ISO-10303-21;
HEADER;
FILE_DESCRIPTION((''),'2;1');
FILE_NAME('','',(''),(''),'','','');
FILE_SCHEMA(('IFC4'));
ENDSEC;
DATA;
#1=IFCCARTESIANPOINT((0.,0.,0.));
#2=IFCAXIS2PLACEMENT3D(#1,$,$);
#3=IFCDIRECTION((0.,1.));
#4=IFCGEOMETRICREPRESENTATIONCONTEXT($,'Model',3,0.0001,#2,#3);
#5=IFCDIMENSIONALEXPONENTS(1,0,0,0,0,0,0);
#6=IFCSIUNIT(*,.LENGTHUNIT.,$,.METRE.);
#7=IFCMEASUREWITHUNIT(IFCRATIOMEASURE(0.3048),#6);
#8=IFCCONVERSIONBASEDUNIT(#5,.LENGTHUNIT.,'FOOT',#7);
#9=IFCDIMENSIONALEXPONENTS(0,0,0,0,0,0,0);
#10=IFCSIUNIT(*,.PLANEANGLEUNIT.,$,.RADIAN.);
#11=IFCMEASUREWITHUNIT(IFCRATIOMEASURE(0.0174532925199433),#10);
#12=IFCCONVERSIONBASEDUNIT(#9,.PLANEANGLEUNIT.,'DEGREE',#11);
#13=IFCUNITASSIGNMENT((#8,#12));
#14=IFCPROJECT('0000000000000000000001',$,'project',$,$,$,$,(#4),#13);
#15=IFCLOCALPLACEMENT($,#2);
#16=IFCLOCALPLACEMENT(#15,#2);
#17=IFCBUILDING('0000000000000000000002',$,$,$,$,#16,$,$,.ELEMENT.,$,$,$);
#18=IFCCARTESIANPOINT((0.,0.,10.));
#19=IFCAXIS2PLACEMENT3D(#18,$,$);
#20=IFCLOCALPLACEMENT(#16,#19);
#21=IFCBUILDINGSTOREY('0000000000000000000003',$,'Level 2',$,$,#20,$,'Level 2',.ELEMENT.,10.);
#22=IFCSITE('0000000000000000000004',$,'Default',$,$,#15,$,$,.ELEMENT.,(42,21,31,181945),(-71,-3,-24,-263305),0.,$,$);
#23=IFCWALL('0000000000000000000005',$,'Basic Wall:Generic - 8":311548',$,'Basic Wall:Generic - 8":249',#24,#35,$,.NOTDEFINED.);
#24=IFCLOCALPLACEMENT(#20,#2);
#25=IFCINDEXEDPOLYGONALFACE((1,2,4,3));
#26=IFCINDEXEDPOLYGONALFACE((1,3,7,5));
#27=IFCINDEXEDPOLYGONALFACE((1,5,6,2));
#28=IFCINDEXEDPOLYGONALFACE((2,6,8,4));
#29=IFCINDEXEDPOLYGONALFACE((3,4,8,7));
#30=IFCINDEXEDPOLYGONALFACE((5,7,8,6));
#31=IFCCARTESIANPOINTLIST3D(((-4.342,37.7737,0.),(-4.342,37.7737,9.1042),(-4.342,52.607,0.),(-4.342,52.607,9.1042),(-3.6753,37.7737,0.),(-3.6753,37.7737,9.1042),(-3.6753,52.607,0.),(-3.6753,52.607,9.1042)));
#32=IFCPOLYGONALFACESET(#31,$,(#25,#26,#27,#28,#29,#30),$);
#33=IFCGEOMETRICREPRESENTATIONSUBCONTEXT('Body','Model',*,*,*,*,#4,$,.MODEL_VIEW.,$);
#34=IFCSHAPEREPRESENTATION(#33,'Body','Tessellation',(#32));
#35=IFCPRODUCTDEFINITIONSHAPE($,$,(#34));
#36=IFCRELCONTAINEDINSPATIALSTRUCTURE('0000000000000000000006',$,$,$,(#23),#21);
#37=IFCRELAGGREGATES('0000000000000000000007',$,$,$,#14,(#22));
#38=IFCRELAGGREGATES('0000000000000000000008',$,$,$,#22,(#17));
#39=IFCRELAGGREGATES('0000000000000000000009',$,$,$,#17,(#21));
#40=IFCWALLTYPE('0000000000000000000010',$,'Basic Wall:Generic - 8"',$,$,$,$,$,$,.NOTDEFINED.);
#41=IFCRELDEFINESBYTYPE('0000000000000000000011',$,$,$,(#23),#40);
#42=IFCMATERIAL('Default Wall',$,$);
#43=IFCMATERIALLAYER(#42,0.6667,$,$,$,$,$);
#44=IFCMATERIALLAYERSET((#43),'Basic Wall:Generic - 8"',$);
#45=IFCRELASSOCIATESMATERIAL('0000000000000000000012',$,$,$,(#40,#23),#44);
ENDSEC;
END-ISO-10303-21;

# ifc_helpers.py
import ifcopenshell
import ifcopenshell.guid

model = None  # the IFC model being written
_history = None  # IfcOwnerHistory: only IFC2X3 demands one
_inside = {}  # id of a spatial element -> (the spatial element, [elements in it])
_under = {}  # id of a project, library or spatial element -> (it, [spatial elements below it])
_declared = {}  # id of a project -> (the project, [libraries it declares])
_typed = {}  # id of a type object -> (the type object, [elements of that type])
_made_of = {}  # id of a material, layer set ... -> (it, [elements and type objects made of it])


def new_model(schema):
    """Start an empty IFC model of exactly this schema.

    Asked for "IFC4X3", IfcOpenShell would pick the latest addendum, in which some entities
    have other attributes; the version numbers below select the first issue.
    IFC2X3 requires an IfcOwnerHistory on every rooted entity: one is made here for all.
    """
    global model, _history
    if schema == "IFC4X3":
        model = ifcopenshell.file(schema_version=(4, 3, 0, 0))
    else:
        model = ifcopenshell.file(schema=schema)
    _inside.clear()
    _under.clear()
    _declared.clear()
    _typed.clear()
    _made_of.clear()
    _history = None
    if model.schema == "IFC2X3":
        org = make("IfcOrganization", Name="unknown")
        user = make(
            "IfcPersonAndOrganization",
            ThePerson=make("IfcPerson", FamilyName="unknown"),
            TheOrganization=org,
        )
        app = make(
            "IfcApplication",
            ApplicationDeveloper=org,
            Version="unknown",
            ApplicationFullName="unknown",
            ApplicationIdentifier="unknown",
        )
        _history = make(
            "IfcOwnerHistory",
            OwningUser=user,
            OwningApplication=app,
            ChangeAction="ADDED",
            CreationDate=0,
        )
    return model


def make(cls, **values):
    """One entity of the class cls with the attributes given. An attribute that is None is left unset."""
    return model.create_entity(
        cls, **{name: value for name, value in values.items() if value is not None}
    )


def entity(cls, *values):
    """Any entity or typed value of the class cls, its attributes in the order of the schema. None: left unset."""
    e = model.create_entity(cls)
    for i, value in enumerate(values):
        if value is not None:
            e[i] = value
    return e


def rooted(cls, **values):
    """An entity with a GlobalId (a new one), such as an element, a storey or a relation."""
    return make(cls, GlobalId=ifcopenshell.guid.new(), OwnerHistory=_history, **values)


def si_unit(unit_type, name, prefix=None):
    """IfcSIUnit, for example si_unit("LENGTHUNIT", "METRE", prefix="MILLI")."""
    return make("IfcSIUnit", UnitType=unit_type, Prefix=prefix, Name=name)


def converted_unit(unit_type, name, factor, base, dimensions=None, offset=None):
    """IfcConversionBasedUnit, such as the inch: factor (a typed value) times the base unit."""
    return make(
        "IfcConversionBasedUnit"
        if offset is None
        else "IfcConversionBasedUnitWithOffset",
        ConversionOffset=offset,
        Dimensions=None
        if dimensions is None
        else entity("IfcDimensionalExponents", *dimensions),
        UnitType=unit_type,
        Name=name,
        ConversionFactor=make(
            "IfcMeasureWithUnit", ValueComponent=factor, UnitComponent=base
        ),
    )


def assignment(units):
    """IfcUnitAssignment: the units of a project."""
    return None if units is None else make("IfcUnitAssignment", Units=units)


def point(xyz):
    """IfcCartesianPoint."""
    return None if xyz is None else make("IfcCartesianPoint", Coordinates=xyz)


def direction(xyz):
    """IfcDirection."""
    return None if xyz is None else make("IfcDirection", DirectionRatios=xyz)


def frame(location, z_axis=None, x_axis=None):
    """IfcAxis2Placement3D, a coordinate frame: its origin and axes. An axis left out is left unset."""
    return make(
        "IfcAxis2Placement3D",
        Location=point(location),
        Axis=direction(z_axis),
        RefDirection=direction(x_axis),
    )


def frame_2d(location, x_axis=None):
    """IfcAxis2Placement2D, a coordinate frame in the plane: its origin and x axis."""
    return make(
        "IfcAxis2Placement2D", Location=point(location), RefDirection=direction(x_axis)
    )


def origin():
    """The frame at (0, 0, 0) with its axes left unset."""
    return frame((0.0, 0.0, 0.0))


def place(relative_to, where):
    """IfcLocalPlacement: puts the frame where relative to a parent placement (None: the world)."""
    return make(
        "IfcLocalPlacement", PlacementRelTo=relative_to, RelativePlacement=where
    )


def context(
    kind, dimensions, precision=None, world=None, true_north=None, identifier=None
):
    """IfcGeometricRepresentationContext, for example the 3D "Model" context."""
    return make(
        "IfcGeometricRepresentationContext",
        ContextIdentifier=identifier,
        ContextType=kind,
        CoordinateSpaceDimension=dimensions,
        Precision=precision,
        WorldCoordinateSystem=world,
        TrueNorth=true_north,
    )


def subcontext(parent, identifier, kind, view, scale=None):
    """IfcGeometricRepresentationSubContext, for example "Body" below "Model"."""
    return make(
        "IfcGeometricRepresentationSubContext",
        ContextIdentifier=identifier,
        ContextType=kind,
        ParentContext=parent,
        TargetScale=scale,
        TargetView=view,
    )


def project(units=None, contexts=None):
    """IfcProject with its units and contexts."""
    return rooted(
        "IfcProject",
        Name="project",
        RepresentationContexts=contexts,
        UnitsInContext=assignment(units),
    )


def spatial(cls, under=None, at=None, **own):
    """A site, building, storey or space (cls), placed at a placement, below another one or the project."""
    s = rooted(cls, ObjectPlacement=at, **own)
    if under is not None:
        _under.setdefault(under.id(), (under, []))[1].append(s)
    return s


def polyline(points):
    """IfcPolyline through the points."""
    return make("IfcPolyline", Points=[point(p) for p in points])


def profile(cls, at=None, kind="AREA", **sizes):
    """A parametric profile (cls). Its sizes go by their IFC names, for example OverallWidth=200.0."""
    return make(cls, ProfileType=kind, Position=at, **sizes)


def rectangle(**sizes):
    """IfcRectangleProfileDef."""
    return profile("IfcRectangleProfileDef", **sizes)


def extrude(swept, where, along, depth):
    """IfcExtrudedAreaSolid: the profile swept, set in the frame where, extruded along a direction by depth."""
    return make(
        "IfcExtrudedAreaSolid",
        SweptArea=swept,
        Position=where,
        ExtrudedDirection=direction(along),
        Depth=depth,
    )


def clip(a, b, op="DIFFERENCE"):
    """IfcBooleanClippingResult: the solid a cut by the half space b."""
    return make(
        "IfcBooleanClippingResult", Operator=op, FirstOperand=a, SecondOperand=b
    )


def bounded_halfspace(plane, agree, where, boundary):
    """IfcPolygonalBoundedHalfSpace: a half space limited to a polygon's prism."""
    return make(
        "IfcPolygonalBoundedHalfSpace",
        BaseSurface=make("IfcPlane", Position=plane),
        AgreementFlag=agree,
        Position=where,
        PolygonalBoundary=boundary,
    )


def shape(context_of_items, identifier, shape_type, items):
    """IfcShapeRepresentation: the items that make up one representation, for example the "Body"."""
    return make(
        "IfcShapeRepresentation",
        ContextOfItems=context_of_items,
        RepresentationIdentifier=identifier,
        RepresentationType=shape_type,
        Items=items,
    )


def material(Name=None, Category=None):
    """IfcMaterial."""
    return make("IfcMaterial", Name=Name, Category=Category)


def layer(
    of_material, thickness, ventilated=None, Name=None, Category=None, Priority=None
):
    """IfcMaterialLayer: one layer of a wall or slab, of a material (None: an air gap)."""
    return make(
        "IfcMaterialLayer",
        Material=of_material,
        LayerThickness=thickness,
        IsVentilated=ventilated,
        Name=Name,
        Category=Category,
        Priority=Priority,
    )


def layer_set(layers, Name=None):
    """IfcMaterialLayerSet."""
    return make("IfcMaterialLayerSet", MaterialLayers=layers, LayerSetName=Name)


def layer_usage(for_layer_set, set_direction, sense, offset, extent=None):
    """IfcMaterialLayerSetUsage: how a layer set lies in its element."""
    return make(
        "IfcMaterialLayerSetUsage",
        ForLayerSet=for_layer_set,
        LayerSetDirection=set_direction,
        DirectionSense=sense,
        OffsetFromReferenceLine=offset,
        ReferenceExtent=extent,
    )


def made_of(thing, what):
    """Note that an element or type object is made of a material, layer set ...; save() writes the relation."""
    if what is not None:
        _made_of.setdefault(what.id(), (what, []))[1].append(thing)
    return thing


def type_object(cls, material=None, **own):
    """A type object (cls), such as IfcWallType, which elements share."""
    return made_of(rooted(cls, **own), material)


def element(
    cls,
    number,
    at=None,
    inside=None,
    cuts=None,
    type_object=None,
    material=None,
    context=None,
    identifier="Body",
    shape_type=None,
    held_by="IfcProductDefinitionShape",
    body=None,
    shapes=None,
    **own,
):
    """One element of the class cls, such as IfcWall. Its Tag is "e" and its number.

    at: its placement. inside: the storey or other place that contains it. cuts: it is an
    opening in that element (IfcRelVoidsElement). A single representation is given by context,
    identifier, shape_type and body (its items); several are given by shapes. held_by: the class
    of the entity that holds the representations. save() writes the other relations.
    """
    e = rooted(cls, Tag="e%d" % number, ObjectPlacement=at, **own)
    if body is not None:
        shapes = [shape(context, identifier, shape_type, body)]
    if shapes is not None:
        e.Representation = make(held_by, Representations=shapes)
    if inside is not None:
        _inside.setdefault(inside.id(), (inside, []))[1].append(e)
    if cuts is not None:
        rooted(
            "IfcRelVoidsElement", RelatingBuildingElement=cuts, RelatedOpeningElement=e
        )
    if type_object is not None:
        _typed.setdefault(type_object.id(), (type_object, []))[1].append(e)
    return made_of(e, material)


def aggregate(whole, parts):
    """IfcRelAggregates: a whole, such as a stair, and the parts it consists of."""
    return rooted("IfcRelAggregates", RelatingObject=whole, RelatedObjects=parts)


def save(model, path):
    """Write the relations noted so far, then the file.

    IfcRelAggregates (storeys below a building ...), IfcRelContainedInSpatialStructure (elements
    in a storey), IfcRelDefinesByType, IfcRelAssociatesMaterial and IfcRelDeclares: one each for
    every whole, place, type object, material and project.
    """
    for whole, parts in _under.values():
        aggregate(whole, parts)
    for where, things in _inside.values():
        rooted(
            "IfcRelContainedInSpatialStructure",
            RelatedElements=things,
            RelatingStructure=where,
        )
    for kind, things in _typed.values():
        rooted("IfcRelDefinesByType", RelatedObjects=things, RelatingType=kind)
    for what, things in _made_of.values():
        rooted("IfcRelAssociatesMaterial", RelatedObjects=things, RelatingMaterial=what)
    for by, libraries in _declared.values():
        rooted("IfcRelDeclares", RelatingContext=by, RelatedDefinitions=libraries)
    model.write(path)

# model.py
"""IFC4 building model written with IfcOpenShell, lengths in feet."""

from ifc_helpers import new_model, entity, si_unit, converted_unit, direction, frame, frame_2d, origin, place, context, subcontext, project, spatial, polyline, rectangle, extrude, clip, bounded_halfspace, material, layer, layer_set, layer_usage, type_object, element, save


model = new_model("IFC4")

# Units and contexts
model_context = context("Model", 3, precision=0.0001, world=origin(), true_north=direction((0.0, 1.0)))
body_context = subcontext(model_context, "Body", "Model", "MODEL_VIEW")
ifc_project = project(units=[converted_unit("LENGTHUNIT", "FOOT", entity("IfcRatioMeasure", 0.3048), si_unit("LENGTHUNIT", "METRE"), dimensions=[1, 0, 0, 0, 0, 0, 0]), converted_unit("PLANEANGLEUNIT", "DEGREE", entity("IfcRatioMeasure", 0.0174532925199433), si_unit("PLANEANGLEUNIT", "RADIAN"), dimensions=[0, 0, 0, 0, 0, 0, 0])], contexts=[model_context])

# Site, building, storey
site_placement = place(None, origin())
site = spatial("IfcSite", under=ifc_project, at=site_placement, Name="Default", CompositionType="ELEMENT", RefLatitude=(42, 21, 31, 181945), RefLongitude=(-71, -3, -24, -263305), RefElevation=0.0)
building_placement = place(site_placement, origin())
building = spatial("IfcBuilding", under=site, at=building_placement, CompositionType="ELEMENT")
storey_placement = place(building_placement, frame((0.0, 0.0, 10.0)))
storey = spatial("IfcBuildingStorey", under=building, at=storey_placement, Name="Level 2", LongName="Level 2", CompositionType="ELEMENT", Elevation=10.0)

# Shared definitions
ifc_material_1 = material(Name="Default Wall")
ifc_layer_1 = layer(ifc_material_1, 0.6667)
ifc_layer_set_1 = layer_set([ifc_layer_1], Name="Basic Wall:Generic - 8\"")
wall_type = type_object("IfcWallType", Name="Basic Wall:Generic - 8\"", PredefinedType="NOTDEFINED", material=ifc_layer_set_1)

# Wall
ifc_layer_usage_1 = layer_usage(ifc_layer_set_1, "AXIS2", "NEGATIVE", 0.3333)
wall_1_placement = place(storey_placement, frame((-4.0087, 37.7737, 0.0), z_axis=(0.0, 0.0, 1.0), x_axis=(0.0, 1.0, 0.0)))
element("IfcWall", 1, at=wall_1_placement, inside=storey, type_object=wall_type, material=ifc_layer_usage_1, Name="Basic Wall:Generic - 8\":311548", ObjectType="Basic Wall:Generic - 8\":249", PredefinedType="NOTDEFINED", context=body_context, shape_type="Clipping", body=[
    clip(extrude(rectangle(XDim=14.8333, YDim=0.6667, at=frame_2d((7.4167, 0.0), x_axis=(-1.0, 0.0))), origin(), (0.0, 0.0, 1.0), 9.1042), bounded_halfspace(frame((0.0, -0.3333, 9.1042), z_axis=(0.0, 0.0, -1.0), x_axis=(-1.0, 0.0, 0.0)), True, frame((0.0, -0.3333, 9.1042), z_axis=(0.0, 0.0, -1.0), x_axis=(-1.0, 0.0, 0.0)), polyline([(0.0, 0.0), (0.0, 0.6667), (-14.8333, 0.6667), (-14.8333, 0.0), (0.0, 0.0)]))),
])

save(model, "model.ifc")
